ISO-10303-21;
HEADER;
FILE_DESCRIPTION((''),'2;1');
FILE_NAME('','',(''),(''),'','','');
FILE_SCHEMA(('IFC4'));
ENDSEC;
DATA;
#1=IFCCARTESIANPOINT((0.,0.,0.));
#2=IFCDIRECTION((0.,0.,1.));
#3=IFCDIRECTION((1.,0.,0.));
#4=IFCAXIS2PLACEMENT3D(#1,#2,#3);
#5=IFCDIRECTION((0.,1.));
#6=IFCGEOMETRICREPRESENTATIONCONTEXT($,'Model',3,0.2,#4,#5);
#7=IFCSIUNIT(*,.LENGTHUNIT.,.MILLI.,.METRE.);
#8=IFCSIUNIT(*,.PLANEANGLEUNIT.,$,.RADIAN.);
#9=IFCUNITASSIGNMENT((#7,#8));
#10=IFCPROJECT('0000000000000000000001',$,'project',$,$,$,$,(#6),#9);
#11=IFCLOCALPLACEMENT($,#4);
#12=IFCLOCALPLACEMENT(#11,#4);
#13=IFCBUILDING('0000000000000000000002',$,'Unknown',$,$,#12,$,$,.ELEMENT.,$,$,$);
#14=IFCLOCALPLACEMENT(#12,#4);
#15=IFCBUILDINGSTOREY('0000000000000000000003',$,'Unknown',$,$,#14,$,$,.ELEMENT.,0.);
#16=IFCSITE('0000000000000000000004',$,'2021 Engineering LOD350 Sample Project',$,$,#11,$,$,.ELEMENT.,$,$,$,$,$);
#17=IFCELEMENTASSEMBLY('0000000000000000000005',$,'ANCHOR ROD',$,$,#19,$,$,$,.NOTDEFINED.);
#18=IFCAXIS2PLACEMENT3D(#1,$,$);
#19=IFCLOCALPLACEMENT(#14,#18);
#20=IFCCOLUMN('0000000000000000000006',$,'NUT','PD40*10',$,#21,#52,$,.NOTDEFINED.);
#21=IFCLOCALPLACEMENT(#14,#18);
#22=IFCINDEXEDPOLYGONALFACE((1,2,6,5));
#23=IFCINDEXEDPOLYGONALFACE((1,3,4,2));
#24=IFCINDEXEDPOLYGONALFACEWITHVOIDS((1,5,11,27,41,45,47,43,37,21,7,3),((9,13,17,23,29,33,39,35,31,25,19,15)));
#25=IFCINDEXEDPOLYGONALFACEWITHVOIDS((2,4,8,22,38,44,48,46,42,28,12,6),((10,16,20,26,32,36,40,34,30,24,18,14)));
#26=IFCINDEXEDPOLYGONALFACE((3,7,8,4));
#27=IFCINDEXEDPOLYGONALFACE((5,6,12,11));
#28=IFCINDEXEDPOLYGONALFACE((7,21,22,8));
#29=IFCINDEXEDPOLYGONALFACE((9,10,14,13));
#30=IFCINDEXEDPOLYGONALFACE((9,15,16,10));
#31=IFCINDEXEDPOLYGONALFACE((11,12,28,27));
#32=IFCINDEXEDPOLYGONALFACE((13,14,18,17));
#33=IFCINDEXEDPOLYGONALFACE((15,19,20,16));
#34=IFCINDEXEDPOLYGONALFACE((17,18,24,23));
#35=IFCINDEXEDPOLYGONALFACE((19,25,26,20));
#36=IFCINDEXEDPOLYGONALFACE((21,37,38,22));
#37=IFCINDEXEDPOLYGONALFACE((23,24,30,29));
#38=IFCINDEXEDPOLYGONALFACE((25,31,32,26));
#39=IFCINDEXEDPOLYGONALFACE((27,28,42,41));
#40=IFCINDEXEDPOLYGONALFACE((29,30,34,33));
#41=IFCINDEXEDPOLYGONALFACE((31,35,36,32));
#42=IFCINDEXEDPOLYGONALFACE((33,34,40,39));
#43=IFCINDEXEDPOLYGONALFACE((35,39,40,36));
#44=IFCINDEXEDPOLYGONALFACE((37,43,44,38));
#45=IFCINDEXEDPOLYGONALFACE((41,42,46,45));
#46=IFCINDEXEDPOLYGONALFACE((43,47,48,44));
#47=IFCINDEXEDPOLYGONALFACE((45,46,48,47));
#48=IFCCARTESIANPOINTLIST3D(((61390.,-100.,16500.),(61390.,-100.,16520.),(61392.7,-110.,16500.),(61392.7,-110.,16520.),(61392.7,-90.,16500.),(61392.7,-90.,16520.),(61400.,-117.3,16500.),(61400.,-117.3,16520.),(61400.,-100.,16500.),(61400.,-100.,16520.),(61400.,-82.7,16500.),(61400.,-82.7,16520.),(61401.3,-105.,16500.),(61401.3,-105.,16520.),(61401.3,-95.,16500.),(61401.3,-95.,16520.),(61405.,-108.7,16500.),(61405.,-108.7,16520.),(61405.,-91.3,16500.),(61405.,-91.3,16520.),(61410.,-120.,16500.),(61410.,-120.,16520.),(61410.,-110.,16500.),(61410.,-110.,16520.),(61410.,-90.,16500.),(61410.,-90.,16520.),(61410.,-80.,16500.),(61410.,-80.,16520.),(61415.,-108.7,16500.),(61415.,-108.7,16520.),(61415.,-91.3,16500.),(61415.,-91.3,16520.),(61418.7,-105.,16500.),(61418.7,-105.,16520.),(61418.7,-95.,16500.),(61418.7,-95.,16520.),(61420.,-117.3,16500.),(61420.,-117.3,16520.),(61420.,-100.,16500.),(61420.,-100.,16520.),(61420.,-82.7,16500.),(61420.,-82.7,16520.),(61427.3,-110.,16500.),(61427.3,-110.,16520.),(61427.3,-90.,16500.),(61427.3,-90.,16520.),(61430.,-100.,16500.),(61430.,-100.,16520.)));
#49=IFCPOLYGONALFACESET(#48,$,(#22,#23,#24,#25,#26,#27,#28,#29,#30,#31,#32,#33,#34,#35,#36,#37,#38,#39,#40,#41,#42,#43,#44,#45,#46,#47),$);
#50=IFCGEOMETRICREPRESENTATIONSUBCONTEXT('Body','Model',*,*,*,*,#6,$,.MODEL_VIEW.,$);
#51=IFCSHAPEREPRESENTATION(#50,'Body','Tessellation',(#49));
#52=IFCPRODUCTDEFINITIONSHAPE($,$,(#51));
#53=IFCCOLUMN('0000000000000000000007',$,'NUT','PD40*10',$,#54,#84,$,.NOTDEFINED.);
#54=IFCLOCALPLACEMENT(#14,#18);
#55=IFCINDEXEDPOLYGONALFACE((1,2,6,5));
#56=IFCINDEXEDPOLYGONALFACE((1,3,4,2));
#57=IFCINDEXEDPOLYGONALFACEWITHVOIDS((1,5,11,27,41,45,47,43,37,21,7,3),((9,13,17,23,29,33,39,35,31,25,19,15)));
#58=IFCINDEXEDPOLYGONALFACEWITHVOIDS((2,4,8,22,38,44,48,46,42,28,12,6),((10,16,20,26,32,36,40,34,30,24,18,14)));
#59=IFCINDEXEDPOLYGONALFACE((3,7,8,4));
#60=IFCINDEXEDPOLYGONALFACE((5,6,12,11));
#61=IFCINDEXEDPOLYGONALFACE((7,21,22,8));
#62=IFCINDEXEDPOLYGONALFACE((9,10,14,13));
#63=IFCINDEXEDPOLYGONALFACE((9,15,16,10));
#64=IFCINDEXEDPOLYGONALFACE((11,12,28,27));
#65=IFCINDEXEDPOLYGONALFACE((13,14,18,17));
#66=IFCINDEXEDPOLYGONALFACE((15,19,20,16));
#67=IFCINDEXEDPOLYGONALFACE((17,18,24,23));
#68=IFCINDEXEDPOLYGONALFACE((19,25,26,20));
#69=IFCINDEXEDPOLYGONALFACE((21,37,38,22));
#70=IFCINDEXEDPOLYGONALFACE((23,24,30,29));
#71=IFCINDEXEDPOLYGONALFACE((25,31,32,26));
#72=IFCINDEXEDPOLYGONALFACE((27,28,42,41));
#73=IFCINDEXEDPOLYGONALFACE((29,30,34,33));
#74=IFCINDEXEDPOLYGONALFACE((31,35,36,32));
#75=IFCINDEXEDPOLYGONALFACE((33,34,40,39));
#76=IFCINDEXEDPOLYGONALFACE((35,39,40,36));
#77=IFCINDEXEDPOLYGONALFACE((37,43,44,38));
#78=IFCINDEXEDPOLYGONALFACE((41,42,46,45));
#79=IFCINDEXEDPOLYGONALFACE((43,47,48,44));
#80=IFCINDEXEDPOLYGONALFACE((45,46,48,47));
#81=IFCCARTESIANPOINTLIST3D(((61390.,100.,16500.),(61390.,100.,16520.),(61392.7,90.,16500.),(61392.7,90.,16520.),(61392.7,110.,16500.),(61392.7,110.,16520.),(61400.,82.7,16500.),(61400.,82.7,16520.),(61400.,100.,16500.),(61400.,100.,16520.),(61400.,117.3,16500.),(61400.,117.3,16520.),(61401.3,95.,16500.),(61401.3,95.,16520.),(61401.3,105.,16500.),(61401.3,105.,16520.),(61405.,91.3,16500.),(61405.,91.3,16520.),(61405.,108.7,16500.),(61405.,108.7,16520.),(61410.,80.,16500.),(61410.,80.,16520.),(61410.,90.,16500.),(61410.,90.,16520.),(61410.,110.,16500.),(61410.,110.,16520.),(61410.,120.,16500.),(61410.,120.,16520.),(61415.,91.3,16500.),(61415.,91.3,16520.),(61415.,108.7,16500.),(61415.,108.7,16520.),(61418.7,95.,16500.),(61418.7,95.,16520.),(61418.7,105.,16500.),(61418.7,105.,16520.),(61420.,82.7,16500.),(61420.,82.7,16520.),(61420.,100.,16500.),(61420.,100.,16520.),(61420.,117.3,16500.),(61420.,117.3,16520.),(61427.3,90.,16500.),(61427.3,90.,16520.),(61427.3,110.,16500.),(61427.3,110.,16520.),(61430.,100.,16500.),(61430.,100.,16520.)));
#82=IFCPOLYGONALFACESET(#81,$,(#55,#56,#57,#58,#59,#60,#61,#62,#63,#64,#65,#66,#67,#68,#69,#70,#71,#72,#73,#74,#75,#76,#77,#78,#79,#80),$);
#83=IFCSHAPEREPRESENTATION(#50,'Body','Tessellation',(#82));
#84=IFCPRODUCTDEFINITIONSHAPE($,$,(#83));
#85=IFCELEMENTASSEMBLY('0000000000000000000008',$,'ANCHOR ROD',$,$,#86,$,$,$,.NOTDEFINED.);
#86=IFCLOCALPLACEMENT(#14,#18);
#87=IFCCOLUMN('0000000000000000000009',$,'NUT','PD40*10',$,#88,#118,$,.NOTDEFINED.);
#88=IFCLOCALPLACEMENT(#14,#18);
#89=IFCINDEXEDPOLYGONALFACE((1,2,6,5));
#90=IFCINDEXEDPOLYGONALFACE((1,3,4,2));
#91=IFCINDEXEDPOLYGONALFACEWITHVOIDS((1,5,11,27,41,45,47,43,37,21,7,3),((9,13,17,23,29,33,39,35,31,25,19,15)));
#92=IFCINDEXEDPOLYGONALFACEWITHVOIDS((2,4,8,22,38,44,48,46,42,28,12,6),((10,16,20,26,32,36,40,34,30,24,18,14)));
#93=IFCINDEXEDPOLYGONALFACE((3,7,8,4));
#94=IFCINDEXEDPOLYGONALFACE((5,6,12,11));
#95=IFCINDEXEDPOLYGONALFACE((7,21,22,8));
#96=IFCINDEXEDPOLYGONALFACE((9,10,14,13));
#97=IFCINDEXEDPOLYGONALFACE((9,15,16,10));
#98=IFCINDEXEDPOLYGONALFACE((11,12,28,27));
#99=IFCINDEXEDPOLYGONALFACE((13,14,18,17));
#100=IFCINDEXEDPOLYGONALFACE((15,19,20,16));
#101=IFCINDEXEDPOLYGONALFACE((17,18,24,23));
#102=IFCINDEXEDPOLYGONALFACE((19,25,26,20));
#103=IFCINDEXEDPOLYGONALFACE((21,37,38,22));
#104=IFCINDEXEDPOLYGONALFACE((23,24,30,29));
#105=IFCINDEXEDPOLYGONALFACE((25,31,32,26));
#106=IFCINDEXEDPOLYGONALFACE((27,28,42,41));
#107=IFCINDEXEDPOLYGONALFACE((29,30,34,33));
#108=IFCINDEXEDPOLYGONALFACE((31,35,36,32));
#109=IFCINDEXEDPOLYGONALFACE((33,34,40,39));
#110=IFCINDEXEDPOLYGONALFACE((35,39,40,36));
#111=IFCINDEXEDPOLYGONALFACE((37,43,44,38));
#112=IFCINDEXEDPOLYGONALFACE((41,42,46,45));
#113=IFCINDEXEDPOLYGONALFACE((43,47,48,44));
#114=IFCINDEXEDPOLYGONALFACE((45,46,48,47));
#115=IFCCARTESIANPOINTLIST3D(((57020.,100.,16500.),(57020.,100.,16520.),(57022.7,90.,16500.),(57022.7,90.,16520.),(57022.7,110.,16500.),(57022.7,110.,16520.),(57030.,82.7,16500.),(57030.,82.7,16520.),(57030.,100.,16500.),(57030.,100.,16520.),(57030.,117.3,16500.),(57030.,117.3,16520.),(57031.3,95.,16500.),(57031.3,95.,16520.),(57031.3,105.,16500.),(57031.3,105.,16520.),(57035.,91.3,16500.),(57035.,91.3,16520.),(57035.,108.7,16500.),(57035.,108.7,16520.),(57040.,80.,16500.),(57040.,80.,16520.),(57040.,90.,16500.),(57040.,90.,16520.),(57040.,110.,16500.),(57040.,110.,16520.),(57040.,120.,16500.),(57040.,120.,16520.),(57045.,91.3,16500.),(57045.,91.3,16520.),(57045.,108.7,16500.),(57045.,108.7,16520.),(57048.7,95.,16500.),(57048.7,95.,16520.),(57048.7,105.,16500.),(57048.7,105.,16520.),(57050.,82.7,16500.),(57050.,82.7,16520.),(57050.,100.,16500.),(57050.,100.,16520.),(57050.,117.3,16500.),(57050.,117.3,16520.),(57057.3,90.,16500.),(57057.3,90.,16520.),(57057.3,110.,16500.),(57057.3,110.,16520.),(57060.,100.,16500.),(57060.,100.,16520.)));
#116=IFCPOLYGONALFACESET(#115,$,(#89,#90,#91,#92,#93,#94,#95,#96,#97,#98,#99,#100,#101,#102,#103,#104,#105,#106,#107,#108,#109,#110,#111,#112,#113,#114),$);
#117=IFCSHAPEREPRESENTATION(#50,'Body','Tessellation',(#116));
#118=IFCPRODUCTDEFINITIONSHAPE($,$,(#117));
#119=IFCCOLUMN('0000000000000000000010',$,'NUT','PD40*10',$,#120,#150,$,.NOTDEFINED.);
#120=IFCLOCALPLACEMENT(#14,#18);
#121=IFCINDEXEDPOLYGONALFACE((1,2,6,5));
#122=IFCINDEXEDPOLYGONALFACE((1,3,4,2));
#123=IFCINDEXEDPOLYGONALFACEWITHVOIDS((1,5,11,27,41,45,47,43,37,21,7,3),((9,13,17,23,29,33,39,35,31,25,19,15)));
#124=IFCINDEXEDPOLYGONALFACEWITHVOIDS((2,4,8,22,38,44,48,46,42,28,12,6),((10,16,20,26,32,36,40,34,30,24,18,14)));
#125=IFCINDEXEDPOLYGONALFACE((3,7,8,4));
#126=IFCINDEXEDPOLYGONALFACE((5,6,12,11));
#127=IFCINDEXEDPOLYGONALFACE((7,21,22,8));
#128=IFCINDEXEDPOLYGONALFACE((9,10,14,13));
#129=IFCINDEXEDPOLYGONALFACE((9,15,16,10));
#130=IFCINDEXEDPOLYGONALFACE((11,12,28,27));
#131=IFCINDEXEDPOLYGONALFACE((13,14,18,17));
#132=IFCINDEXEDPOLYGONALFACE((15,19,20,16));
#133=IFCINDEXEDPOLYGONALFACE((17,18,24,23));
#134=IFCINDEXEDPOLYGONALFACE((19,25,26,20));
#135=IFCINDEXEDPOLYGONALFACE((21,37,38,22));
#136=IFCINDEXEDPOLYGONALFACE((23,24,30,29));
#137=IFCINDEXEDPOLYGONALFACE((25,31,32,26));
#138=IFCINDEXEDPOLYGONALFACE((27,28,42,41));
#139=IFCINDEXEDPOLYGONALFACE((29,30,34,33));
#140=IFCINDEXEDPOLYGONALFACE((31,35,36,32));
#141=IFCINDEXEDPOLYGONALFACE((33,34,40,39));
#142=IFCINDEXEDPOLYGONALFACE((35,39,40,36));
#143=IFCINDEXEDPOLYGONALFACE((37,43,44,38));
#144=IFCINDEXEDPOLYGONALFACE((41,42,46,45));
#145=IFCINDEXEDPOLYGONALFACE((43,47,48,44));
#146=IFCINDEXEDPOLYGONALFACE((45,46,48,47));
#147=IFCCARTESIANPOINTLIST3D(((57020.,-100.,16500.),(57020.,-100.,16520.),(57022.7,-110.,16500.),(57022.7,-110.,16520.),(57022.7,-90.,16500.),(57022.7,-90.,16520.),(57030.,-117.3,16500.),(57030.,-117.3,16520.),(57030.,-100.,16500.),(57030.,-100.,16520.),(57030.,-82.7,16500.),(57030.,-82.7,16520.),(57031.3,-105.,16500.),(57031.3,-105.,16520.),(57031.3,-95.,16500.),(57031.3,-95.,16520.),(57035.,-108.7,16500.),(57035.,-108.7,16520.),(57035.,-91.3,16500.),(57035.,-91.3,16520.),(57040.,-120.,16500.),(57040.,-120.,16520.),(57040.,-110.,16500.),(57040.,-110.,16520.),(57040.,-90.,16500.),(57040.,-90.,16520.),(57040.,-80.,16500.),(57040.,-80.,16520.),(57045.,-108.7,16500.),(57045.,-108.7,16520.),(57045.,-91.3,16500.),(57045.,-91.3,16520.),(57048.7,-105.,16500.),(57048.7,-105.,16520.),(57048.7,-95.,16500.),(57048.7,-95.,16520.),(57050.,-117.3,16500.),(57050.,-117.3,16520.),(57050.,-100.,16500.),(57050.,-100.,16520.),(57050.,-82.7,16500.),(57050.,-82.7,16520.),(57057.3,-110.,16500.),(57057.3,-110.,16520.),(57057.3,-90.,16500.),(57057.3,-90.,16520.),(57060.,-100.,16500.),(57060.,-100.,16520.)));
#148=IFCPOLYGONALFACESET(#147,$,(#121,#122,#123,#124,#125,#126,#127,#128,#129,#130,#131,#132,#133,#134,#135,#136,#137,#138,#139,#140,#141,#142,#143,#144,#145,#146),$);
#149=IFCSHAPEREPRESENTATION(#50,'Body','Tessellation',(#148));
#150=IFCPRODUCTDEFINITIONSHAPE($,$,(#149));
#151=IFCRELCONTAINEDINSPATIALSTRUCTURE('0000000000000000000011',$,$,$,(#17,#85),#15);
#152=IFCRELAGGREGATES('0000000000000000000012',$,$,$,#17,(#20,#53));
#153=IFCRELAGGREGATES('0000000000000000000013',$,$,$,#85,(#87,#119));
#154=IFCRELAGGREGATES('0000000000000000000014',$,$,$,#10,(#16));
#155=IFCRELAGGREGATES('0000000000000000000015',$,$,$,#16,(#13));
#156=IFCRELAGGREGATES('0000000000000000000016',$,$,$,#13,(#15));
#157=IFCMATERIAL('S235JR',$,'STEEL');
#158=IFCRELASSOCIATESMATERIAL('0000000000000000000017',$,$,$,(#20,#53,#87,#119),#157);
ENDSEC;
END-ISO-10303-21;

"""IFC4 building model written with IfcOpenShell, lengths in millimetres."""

from ifc_helpers import new_model, si_unit, direction, frame, origin_with_axes, place, context, subcontext, project, spatial, line, indexed_curve, outline, extrude, material, element, aggregate, save


model = new_model("IFC4")

# Units and contexts
model_context = context("Model", 3, precision=0.2, world=origin_with_axes(), true_north=direction((0.0, 1.0)))
body_context = subcontext(model_context, "Body", "Model", "MODEL_VIEW")
ifc_project = project(units=[si_unit("LENGTHUNIT", "METRE", prefix="MILLI"), si_unit("PLANEANGLEUNIT", "RADIAN")], contexts=[model_context])

# Site, building, storey
site_placement = place(None, origin_with_axes())
site = spatial("IfcSite", under=ifc_project, at=site_placement, Name="2021 Engineering LOD350 Sample Project", CompositionType="ELEMENT")
building_placement = place(site_placement, origin_with_axes())
building = spatial("IfcBuilding", under=site, at=building_placement, Name="Unknown", CompositionType="ELEMENT")
storey_placement = place(building_placement, origin_with_axes())
storey = spatial("IfcBuildingStorey", under=building, at=storey_placement, Name="Unknown", CompositionType="ELEMENT", Elevation=0.0)

# Element assemblies, columns
assembly_1_placement = place(storey_placement, frame((61790.0, 100.0, 16730.0), z_axis=(1.0, 0.0, 0.0), x_axis=(0.0, 0.0, -1.0)))
assembly_1 = element("IfcElementAssembly", 1, at=assembly_1_placement, inside=storey, Name="ANCHOR ROD", PredefinedType="NOTDEFINED")
ifc_material_1 = material(Name="S235JR", Category="STEEL")
column_1_placement = place(assembly_1_placement, frame((210.0, -200.0, -380.0), z_axis=(0.0, 0.0, -1.0), x_axis=(1.0, 0.0, 0.0)))
column_1 = element("IfcColumn", 2, at=column_1_placement, material=ifc_material_1, Name="NUT", Description="PD40*10", PredefinedType="NOTDEFINED", context=body_context, shape_type="SolidModel", body=[
    extrude(outline(indexed_curve([(20.0, 0.0), (17.3, 10.0), (10.0, 17.3), (0.0, 20.0), (-10.0, 17.3), (-17.3, 10.0), (-20.0, 0.0), (-17.3, -10.0), (-10.0, -17.3), (0.0, -20.0), (10.0, -17.3), (17.3, -10.0)], segments=[line(1, 2, 3, 4, 5, 6, 7, 8, 9, 10, 11, 12, 1)]), holes=[indexed_curve([(10.0, 0.0), (8.7, -5.0), (5.0, -8.7), (0.0, -10.0), (-5.0, -8.7), (-8.7, -5.0), (-10.0, 0.0), (-8.7, 5.0), (-5.0, 8.7), (0.0, 10.0), (5.0, 8.7), (8.7, 5.0)], segments=[line(1, 2, 3, 4, 5, 6, 7, 8, 9, 10, 11, 12, 1)])]), frame((0.0, 0.0, 0.0), z_axis=(-1.0, 0.0, 0.0), x_axis=(0.0, 0.0, 1.0)), (0.0, 0.0, -1.0), 20.0),
])
column_2_placement = place(assembly_1_placement, frame((210.0, 0.0, -380.0), z_axis=(0.0, 0.0, -1.0), x_axis=(1.0, 0.0, 0.0)))
column_2 = element("IfcColumn", 3, at=column_2_placement, material=ifc_material_1, Name="NUT", Description="PD40*10", PredefinedType="NOTDEFINED", context=body_context, shape_type="SolidModel", body=[
    extrude(outline(indexed_curve([(20.0, 0.0), (17.3, 10.0), (10.0, 17.3), (0.0, 20.0), (-10.0, 17.3), (-17.3, 10.0), (-20.0, 0.0), (-17.3, -10.0), (-10.0, -17.3), (0.0, -20.0), (10.0, -17.3), (17.3, -10.0)], segments=[line(1, 2, 3, 4, 5, 6, 7, 8, 9, 10, 11, 12, 1)]), holes=[indexed_curve([(10.0, 0.0), (8.7, -5.0), (5.0, -8.7), (0.0, -10.0), (-5.0, -8.7), (-8.7, -5.0), (-10.0, 0.0), (-8.7, 5.0), (-5.0, 8.7), (0.0, 10.0), (5.0, 8.7), (8.7, 5.0)], segments=[line(1, 2, 3, 4, 5, 6, 7, 8, 9, 10, 11, 12, 1)])]), frame((0.0, 0.0, 0.0), z_axis=(-1.0, 0.0, 0.0), x_axis=(0.0, 0.0, 1.0)), (0.0, 0.0, -1.0), 20.0),
])
assembly_2_placement = place(storey_placement, frame((57040.0, 100.0, 16730.0), z_axis=(1.0, 0.0, 0.0), x_axis=(0.0, 0.0, -1.0)))
assembly_2 = element("IfcElementAssembly", 4, at=assembly_2_placement, inside=storey, Name="ANCHOR ROD", PredefinedType="NOTDEFINED")
column_3_placement = place(assembly_2_placement, frame((210.0, 0.0, 0.0), z_axis=(0.0, 0.0, 1.0), x_axis=(1.0, 0.0, 0.0)))
column_3 = element("IfcColumn", 5, at=column_3_placement, material=ifc_material_1, Name="NUT", Description="PD40*10", PredefinedType="NOTDEFINED", context=body_context, shape_type="SolidModel", body=[
    extrude(outline(indexed_curve([(20.0, 0.0), (17.3, 10.0), (10.0, 17.3), (0.0, 20.0), (-10.0, 17.3), (-17.3, 10.0), (-20.0, 0.0), (-17.3, -10.0), (-10.0, -17.3), (0.0, -20.0), (10.0, -17.3), (17.3, -10.0)], segments=[line(1, 2, 3, 4, 5, 6, 7, 8, 9, 10, 11, 12, 1)]), holes=[indexed_curve([(10.0, 0.0), (8.7, -5.0), (5.0, -8.7), (0.0, -10.0), (-5.0, -8.7), (-8.7, -5.0), (-10.0, 0.0), (-8.7, 5.0), (-5.0, 8.7), (0.0, 10.0), (5.0, 8.7), (8.7, 5.0)], segments=[line(1, 2, 3, 4, 5, 6, 7, 8, 9, 10, 11, 12, 1)])]), frame((0.0, 0.0, 0.0), z_axis=(-1.0, 0.0, 0.0), x_axis=(0.0, 0.0, 1.0)), (0.0, 0.0, -1.0), 20.0),
])
column_4_placement = place(assembly_2_placement, frame((210.0, -200.0, 0.0), z_axis=(0.0, 0.0, 1.0), x_axis=(1.0, 0.0, 0.0)))
column_4 = element("IfcColumn", 6, at=column_4_placement, material=ifc_material_1, Name="NUT", Description="PD40*10", PredefinedType="NOTDEFINED", context=body_context, shape_type="SolidModel", body=[
    extrude(outline(indexed_curve([(20.0, 0.0), (17.3, 10.0), (10.0, 17.3), (0.0, 20.0), (-10.0, 17.3), (-17.3, 10.0), (-20.0, 0.0), (-17.3, -10.0), (-10.0, -17.3), (0.0, -20.0), (10.0, -17.3), (17.3, -10.0)], segments=[line(1, 2, 3, 4, 5, 6, 7, 8, 9, 10, 11, 12, 1)]), holes=[indexed_curve([(10.0, 0.0), (8.7, -5.0), (5.0, -8.7), (0.0, -10.0), (-5.0, -8.7), (-8.7, -5.0), (-10.0, 0.0), (-8.7, 5.0), (-5.0, 8.7), (0.0, 10.0), (5.0, 8.7), (8.7, 5.0)], segments=[line(1, 2, 3, 4, 5, 6, 7, 8, 9, 10, 11, 12, 1)])]), frame((0.0, 0.0, 0.0), z_axis=(-1.0, 0.0, 0.0), x_axis=(0.0, 0.0, 1.0)), (0.0, 0.0, -1.0), 20.0),
])

aggregate(assembly_1, [column_1, column_2])
aggregate(assembly_2, [column_3, column_4])

save(model, "model.ifc")
